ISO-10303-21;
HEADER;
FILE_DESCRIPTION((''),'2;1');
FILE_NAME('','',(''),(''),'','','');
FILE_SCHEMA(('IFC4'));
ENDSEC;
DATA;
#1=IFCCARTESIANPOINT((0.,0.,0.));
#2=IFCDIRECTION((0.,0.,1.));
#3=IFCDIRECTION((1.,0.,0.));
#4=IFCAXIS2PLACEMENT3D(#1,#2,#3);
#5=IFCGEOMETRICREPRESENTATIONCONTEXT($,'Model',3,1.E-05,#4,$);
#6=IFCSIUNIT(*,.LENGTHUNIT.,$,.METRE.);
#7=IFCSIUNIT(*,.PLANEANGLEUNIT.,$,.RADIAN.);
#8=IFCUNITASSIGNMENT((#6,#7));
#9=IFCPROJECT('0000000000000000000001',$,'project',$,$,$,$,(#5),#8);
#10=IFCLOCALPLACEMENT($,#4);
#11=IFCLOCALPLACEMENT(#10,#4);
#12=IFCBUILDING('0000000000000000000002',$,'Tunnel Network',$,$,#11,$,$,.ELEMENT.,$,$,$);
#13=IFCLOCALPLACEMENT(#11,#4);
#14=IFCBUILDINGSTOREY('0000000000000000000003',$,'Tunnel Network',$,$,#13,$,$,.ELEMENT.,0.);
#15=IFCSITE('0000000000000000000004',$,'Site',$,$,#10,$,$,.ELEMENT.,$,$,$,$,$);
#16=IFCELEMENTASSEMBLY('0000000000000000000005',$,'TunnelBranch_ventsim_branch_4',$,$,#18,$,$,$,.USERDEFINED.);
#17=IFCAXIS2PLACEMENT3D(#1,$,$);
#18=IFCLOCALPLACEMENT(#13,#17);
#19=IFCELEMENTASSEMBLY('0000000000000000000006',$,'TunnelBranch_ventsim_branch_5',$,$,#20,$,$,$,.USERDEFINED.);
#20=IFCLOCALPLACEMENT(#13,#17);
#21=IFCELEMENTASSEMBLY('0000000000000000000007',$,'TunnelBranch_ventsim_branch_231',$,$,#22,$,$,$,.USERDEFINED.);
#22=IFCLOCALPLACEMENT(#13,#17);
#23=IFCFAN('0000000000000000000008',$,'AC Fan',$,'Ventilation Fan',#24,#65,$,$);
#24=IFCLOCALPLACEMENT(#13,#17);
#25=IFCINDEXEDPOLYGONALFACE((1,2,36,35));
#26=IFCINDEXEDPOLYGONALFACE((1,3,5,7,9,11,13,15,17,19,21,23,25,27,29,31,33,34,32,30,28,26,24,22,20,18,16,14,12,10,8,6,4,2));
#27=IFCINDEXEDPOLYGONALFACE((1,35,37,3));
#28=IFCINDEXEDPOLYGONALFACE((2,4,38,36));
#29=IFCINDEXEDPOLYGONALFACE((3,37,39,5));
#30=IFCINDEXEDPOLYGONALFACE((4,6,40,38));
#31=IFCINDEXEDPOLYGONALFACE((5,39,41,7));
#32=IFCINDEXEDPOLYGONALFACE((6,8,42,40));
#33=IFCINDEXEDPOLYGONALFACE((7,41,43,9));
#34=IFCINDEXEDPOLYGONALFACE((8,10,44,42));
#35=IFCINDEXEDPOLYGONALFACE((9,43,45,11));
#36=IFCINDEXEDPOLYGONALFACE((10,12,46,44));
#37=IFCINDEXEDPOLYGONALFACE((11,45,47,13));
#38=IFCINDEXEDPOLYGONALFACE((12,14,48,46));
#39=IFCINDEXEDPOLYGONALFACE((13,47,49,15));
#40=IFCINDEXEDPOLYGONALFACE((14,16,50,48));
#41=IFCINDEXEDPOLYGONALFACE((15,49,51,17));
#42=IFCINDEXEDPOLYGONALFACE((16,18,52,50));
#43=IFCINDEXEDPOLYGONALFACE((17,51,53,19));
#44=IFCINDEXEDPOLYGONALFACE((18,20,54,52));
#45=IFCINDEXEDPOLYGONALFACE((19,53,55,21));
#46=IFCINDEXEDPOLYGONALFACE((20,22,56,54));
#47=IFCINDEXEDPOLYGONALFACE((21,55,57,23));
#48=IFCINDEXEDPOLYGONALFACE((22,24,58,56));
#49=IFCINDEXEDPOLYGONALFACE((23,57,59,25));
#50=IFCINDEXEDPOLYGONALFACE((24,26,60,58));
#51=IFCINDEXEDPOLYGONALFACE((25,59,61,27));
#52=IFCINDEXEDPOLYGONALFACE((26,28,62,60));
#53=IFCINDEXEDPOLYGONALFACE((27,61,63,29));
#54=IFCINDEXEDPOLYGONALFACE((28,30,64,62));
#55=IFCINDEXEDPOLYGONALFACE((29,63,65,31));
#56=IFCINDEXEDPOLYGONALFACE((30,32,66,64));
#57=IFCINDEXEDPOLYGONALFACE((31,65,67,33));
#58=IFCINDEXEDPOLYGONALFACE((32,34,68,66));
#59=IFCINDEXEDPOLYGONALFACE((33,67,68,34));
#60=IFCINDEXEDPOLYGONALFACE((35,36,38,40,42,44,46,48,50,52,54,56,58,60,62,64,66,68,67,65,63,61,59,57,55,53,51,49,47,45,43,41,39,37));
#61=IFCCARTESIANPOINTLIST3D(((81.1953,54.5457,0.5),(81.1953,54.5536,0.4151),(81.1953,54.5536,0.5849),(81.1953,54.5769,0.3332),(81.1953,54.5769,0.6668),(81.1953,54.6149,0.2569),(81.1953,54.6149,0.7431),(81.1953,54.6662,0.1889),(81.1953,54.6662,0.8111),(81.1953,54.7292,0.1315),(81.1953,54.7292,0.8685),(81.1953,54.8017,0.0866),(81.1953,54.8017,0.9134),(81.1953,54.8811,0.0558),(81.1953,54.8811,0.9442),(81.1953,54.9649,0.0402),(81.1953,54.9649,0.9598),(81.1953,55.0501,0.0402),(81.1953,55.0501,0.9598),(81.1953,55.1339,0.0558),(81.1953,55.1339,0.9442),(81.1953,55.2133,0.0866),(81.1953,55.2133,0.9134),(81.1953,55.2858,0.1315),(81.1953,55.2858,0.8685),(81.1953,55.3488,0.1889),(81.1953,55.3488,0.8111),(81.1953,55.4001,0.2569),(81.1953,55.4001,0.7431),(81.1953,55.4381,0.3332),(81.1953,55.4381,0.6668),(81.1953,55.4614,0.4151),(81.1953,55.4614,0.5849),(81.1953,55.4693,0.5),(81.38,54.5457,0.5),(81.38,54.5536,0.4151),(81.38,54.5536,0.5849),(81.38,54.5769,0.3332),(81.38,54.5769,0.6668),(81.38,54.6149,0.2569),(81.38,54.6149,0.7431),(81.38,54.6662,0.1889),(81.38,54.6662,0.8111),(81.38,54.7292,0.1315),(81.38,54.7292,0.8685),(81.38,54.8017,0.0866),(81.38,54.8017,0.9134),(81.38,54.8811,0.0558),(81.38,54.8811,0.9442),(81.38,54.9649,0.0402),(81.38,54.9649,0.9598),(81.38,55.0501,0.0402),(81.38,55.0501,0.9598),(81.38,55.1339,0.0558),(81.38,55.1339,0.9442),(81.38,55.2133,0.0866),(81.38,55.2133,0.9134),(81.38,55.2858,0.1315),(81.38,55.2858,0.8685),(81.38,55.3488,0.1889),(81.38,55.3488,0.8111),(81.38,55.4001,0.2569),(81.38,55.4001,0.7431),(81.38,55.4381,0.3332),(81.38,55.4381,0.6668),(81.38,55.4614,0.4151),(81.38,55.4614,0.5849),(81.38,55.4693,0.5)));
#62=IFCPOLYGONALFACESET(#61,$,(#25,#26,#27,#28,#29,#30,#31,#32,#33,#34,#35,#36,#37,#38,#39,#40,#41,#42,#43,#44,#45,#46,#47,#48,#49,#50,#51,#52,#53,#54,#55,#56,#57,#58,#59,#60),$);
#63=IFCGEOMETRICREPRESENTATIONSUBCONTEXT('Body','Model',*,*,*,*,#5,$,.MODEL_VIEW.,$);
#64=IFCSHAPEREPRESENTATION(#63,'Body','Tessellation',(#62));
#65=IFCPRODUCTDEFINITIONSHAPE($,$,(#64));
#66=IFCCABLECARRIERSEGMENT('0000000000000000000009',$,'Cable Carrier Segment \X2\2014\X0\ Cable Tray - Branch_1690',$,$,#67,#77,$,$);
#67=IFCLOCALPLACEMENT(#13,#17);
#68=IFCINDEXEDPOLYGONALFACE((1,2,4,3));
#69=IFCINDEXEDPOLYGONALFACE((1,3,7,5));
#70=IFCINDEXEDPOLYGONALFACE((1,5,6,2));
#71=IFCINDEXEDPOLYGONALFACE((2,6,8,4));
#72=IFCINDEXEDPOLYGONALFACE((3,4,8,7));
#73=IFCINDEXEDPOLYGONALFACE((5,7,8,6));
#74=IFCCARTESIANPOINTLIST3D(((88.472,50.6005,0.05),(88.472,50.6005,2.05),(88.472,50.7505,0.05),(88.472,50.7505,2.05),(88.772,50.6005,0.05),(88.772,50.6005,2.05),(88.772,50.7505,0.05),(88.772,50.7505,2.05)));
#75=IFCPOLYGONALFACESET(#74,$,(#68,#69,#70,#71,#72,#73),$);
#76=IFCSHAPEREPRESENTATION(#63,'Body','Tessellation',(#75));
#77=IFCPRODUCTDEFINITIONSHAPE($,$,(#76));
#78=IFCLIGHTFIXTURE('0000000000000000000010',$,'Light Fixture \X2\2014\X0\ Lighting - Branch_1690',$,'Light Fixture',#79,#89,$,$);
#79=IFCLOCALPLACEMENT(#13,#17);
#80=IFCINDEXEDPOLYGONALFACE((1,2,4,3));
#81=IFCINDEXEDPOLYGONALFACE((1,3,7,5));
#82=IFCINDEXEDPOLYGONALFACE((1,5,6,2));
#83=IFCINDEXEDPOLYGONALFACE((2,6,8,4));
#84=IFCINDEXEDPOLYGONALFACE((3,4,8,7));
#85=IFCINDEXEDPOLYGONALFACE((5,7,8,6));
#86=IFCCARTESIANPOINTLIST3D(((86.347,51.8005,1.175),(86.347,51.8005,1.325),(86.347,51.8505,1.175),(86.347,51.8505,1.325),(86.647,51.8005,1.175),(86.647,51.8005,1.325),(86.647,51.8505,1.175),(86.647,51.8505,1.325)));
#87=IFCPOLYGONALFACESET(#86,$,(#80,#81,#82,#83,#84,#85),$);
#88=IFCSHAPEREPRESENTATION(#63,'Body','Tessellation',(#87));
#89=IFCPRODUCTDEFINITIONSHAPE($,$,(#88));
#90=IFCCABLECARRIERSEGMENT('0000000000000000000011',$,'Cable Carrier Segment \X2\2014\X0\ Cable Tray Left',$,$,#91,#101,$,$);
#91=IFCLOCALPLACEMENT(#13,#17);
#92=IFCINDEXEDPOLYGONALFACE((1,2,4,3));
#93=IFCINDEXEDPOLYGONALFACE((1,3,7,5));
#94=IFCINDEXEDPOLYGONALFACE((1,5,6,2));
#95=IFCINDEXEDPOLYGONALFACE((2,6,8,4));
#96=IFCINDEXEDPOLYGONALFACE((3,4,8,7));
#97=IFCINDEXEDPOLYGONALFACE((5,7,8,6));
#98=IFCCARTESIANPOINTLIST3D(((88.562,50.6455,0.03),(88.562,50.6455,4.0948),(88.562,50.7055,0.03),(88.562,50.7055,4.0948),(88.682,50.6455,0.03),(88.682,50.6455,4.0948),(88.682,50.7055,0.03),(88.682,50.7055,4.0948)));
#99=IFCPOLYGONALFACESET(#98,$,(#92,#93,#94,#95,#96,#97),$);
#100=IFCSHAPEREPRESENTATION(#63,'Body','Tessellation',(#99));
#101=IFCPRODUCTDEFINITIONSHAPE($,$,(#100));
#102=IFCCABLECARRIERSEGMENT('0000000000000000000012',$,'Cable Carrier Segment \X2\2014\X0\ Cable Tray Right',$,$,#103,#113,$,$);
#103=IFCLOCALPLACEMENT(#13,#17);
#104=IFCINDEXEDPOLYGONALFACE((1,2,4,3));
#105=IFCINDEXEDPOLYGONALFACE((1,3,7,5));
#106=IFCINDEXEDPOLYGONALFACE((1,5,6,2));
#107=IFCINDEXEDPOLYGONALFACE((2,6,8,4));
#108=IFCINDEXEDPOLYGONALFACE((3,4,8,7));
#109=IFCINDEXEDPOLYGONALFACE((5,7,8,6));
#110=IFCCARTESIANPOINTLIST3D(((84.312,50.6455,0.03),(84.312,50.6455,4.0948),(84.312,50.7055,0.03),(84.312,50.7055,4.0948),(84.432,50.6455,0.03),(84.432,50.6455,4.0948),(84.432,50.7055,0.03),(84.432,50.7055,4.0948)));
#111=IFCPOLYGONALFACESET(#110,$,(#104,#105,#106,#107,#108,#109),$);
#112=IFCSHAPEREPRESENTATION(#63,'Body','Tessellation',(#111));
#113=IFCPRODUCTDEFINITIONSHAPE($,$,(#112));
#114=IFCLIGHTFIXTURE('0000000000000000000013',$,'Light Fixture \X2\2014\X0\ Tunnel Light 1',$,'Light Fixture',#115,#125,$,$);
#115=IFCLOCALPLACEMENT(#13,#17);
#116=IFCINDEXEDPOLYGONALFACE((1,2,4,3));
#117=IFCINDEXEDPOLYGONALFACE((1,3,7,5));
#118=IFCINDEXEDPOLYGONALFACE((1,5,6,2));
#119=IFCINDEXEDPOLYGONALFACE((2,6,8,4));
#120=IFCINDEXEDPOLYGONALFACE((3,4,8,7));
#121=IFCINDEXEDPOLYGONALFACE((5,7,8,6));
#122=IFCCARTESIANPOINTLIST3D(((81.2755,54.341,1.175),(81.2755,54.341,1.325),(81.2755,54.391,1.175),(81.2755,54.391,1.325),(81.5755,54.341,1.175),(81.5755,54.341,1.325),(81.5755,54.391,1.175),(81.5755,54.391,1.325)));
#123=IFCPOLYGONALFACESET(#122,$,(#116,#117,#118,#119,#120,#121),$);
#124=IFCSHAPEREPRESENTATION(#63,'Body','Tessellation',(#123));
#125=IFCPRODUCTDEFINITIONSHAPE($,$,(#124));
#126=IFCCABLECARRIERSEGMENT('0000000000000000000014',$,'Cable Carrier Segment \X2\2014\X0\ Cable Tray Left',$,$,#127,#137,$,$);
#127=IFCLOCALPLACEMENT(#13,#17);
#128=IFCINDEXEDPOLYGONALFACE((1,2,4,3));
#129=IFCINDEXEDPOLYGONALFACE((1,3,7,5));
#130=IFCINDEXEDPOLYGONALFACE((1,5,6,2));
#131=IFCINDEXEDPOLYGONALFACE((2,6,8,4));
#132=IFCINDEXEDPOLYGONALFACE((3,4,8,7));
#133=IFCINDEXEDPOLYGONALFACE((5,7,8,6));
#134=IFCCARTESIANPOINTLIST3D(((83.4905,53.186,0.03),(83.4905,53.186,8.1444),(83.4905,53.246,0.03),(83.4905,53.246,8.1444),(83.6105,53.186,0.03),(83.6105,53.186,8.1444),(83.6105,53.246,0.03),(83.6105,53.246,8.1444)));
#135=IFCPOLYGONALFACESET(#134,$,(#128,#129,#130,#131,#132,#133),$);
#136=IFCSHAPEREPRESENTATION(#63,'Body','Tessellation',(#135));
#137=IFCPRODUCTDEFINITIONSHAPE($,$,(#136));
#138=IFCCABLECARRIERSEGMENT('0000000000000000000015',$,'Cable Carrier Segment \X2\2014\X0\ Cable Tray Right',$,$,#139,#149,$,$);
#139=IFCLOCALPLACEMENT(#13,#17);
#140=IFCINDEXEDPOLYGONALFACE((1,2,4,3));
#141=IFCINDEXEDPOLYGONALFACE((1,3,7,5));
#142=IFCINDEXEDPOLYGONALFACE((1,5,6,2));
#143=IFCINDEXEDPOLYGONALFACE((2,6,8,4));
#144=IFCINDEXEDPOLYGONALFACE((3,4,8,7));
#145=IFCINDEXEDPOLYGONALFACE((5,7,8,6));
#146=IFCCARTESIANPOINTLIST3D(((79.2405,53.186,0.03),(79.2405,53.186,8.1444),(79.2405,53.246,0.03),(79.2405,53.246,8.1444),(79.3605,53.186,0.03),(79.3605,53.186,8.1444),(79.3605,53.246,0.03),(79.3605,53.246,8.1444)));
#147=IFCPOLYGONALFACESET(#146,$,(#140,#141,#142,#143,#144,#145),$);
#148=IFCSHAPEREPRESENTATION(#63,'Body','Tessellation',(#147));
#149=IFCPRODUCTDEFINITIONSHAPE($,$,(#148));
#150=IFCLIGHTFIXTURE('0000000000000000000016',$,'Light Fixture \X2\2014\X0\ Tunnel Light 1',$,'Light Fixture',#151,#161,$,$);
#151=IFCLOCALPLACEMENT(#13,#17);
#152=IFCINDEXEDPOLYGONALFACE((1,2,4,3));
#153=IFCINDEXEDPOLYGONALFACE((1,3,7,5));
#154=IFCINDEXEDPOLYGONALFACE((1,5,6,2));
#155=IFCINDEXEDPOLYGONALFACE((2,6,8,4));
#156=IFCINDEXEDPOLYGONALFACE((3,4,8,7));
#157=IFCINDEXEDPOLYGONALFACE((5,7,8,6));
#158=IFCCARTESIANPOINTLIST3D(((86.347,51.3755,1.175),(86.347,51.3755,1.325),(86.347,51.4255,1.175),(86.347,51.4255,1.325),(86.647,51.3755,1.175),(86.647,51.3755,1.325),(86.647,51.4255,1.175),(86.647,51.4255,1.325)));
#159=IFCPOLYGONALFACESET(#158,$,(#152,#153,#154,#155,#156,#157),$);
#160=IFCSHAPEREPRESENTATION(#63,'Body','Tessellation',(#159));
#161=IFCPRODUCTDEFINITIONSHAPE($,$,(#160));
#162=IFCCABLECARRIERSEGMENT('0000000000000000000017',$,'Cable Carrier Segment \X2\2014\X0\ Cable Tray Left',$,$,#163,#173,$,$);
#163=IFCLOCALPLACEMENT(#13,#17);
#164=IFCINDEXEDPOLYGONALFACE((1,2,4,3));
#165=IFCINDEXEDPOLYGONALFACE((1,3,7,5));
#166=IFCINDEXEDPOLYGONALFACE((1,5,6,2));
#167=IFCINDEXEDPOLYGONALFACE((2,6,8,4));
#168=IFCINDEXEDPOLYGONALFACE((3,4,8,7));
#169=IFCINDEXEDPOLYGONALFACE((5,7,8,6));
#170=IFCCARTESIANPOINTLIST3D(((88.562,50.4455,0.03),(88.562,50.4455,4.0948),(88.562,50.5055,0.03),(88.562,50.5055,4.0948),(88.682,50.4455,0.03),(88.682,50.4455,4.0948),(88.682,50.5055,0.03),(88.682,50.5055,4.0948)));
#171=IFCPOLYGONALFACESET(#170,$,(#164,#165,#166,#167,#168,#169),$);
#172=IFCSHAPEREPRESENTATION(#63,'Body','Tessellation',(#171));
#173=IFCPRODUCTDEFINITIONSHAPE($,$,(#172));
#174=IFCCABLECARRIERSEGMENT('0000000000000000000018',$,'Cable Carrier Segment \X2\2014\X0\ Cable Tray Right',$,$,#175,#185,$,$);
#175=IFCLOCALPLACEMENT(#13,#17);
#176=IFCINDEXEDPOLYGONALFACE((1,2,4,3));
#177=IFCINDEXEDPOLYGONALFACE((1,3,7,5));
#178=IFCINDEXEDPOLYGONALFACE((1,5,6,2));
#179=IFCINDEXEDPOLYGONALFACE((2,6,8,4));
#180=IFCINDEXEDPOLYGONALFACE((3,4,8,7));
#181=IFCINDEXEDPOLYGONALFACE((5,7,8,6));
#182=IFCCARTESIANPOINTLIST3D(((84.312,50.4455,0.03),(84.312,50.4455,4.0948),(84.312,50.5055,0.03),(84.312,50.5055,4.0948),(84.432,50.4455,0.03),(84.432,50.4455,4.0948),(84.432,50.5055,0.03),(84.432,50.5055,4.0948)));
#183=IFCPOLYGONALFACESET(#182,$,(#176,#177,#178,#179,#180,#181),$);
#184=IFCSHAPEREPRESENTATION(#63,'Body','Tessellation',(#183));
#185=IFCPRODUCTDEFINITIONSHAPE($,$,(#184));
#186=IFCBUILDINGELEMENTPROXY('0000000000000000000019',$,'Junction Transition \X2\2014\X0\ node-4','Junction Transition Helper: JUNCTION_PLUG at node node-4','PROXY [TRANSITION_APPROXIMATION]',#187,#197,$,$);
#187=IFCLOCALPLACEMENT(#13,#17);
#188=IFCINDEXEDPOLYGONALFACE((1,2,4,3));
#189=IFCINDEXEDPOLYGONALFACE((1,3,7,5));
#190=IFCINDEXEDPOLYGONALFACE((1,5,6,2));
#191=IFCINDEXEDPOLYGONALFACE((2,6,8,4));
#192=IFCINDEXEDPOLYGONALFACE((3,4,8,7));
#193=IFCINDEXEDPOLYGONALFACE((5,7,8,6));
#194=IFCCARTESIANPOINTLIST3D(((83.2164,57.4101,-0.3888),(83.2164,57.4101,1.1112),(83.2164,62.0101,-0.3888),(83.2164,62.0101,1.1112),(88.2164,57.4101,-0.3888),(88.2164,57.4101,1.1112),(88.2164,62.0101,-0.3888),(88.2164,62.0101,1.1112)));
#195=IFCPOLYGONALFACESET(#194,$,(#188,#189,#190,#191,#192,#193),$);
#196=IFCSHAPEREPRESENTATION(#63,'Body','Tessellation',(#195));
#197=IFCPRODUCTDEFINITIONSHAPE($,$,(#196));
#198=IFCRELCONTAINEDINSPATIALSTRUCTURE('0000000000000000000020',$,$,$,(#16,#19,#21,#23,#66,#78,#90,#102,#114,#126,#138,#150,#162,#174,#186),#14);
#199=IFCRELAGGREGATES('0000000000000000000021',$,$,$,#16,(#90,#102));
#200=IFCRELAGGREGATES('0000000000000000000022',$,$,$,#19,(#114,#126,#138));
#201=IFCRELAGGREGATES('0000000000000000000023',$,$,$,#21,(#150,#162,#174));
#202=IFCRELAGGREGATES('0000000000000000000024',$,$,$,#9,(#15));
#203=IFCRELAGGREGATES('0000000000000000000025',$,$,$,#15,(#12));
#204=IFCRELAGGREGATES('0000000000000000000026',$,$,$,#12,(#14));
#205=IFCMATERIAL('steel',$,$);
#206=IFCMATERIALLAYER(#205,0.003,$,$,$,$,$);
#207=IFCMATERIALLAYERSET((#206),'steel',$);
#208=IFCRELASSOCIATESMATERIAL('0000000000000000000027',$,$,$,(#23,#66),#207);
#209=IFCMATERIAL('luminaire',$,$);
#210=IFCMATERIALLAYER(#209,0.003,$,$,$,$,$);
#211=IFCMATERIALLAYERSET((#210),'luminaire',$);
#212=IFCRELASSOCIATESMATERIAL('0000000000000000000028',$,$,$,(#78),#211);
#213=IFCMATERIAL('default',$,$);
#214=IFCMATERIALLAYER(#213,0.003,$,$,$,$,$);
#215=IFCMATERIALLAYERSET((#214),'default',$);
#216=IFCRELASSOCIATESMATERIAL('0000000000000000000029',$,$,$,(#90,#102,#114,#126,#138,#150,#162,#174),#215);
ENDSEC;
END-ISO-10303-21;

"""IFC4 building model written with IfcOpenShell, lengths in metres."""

from ifc_helpers import new_model, si_unit, frame, origin_with_axes, origin_2d_with_axis, place, context, subcontext, project, spatial, rectangle, circle, extrude, material, layer, layer_set, layer_usage, element, aggregate, save


model = new_model("IFC4")

# Units and contexts
model_context = context("Model", 3, precision=1e-05, world=origin_with_axes())
body_context = subcontext(model_context, "Body", "Model", "MODEL_VIEW")
ifc_project = project(units=[si_unit("LENGTHUNIT", "METRE"), si_unit("PLANEANGLEUNIT", "RADIAN")], contexts=[model_context])

# Site, building, storey
site_placement = place(None, origin_with_axes())
site = spatial("IfcSite", under=ifc_project, at=site_placement, Name="Site", CompositionType="ELEMENT")
building_placement = place(site_placement, origin_with_axes())
building = spatial("IfcBuilding", under=site, at=building_placement, Name="Tunnel Network", CompositionType="ELEMENT")
storey_placement = place(building_placement, origin_with_axes())
storey = spatial("IfcBuildingStorey", under=building, at=storey_placement, Name="Tunnel Network", CompositionType="ELEMENT", Elevation=0.0)

# Element assemblies
assembly_1_placement = place(storey_placement, frame((86.497, 51.8005, 0.5081), z_axis=(0.0, 0.0, 1.0), x_axis=(-1.0, 0.0, 0.0)))
assembly_1 = element("IfcElementAssembly", 1, at=assembly_1_placement, inside=storey, Name="TunnelBranch_ventsim_branch_4", PredefinedType="USERDEFINED")
ifc_material_1 = material(Name="default")
ifc_layer_1 = layer(ifc_material_1, 0.003)
ifc_layer_set_1 = layer_set([ifc_layer_1], Name="default")
assembly_2_placement = place(storey_placement, frame((78.9255, 52.216, 4.0), z_axis=(0.0, 1.0, 0.0), x_axis=(-1.0, 0.0, 0.0)))
assembly_2 = element("IfcElementAssembly", 2, at=assembly_2_placement, inside=storey, Name="TunnelBranch_ventsim_branch_5", PredefinedType="USERDEFINED")
assembly_3_placement = place(storey_placement, frame((86.497, 51.3755, 1.25), z_axis=(0.0, 1.0, 0.0), x_axis=(-1.0, 0.0, 0.0)))
assembly_3 = element("IfcElementAssembly", 3, at=assembly_3_placement, inside=storey, Name="TunnelBranch_ventsim_branch_231", PredefinedType="USERDEFINED")

# Fan
ifc_material_2 = material(Name="steel")
ifc_layer_2 = layer(ifc_material_2, 0.003)
ifc_layer_set_2 = layer_set([ifc_layer_2], Name="steel")
ifc_layer_usage_1 = layer_usage(ifc_layer_set_2, "AXIS2", "POSITIVE", 0.0)
fan_placement = place(storey_placement, frame((81.38, 55.0075, 0.5), z_axis=(-1.0, 0.0, 0.0), x_axis=(0.0, 1.0, 0.0)))
element("IfcFan", 4, at=fan_placement, inside=storey, material=ifc_layer_usage_1, Name="AC Fan", ObjectType="Ventilation Fan", context=body_context, shape_type="SweptSolid", body=[
    extrude(circle(Radius=0.4618, at=origin_2d_with_axis()), origin_with_axes(), (0.0, 0.0, 1.0), 0.1847),
])

# Cable carrier segment
ifc_layer_usage_2 = layer_usage(ifc_layer_set_2, "AXIS2", "POSITIVE", 0.0)
cable_carrier_segment_1_placement = place(storey_placement, frame((88.622, 50.6755, 0.05), z_axis=(0.0, 0.0, 1.0), x_axis=(-1.0, 0.0, 0.0)))
element("IfcCableCarrierSegment", 5, at=cable_carrier_segment_1_placement, inside=storey, material=ifc_layer_usage_2, Name="Cable Carrier Segment — Cable Tray - Branch_1690", context=body_context, shape_type="SweptSolid", body=[
    extrude(rectangle(XDim=0.3, YDim=0.15, at=origin_2d_with_axis()), origin_with_axes(), (0.0, 0.0, 1.0), 2.0),
])

# Light fixture
ifc_material_3 = material(Name="luminaire")
ifc_layer_3 = layer(ifc_material_3, 0.003)
ifc_layer_set_3 = layer_set([ifc_layer_3], Name="luminaire")
ifc_layer_usage_3 = layer_usage(ifc_layer_set_3, "AXIS2", "POSITIVE", 0.0)
light_fixture_1_placement = place(storey_placement, frame((86.497, 51.8005, 1.25), z_axis=(0.0, 1.0, 0.0), x_axis=(-1.0, 0.0, 0.0)))
element("IfcLightFixture", 6, at=light_fixture_1_placement, inside=storey, material=ifc_layer_usage_3, Name="Light Fixture — Lighting - Branch_1690", ObjectType="Light Fixture", context=body_context, shape_type="SweptSolid", body=[
    extrude(rectangle(XDim=0.3, YDim=0.15, at=origin_2d_with_axis()), origin_with_axes(), (0.0, 0.0, 1.0), 0.05),
])

# Cable carrier segments
ifc_layer_usage_4 = layer_usage(ifc_layer_set_1, "AXIS2", "POSITIVE", 0.0)
cable_carrier_segment_2_placement = place(storey_placement, frame((88.622, 50.6755, 0.03), z_axis=(0.0, 0.0, 1.0), x_axis=(-1.0, 0.0, 0.0)))
cable_carrier_segment_2 = element("IfcCableCarrierSegment", 7, at=cable_carrier_segment_2_placement, inside=storey, material=ifc_layer_usage_4, Name="Cable Carrier Segment — Cable Tray Left", context=body_context, shape_type="SweptSolid", body=[
    extrude(rectangle(XDim=0.12, YDim=0.06, at=origin_2d_with_axis()), origin_with_axes(), (0.0, 0.0, 1.0), 4.0648),
])
ifc_layer_usage_5 = layer_usage(ifc_layer_set_1, "AXIS2", "POSITIVE", 0.0)
cable_carrier_segment_3_placement = place(storey_placement, frame((84.372, 50.6755, 0.03), z_axis=(0.0, 0.0, 1.0), x_axis=(-1.0, 0.0, 0.0)))
cable_carrier_segment_3 = element("IfcCableCarrierSegment", 8, at=cable_carrier_segment_3_placement, inside=storey, material=ifc_layer_usage_5, Name="Cable Carrier Segment — Cable Tray Right", context=body_context, shape_type="SweptSolid", body=[
    extrude(rectangle(XDim=0.12, YDim=0.06, at=origin_2d_with_axis()), origin_with_axes(), (0.0, 0.0, 1.0), 4.0648),
])
aggregate(assembly_1, [cable_carrier_segment_2, cable_carrier_segment_3])

# Light fixture
ifc_layer_usage_6 = layer_usage(ifc_layer_set_1, "AXIS2", "POSITIVE", 0.0)
light_fixture_2_placement = place(storey_placement, frame((81.4255, 54.341, 1.25), z_axis=(0.0, 1.0, 0.0), x_axis=(-1.0, 0.0, 0.0)))
light_fixture_2 = element("IfcLightFixture", 9, at=light_fixture_2_placement, inside=storey, material=ifc_layer_usage_6, Name="Light Fixture — Tunnel Light 1", ObjectType="Light Fixture", context=body_context, shape_type="SweptSolid", body=[
    extrude(rectangle(XDim=0.3, YDim=0.15, at=origin_2d_with_axis()), origin_with_axes(), (0.0, 0.0, 1.0), 0.05),
])

# Cable carrier segments
ifc_layer_usage_7 = layer_usage(ifc_layer_set_1, "AXIS2", "POSITIVE", 0.0)
cable_carrier_segment_4_placement = place(storey_placement, frame((83.5505, 53.216, 0.03), z_axis=(0.0, 0.0, 1.0), x_axis=(-1.0, 0.0, 0.0)))
cable_carrier_segment_4 = element("IfcCableCarrierSegment", 10, at=cable_carrier_segment_4_placement, inside=storey, material=ifc_layer_usage_7, Name="Cable Carrier Segment — Cable Tray Left", context=body_context, shape_type="SweptSolid", body=[
    extrude(rectangle(XDim=0.12, YDim=0.06, at=origin_2d_with_axis()), origin_with_axes(), (0.0, 0.0, 1.0), 8.1144),
])
ifc_layer_usage_8 = layer_usage(ifc_layer_set_1, "AXIS2", "POSITIVE", 0.0)
cable_carrier_segment_5_placement = place(storey_placement, frame((79.3005, 53.216, 0.03), z_axis=(0.0, 0.0, 1.0), x_axis=(-1.0, 0.0, 0.0)))
cable_carrier_segment_5 = element("IfcCableCarrierSegment", 11, at=cable_carrier_segment_5_placement, inside=storey, material=ifc_layer_usage_8, Name="Cable Carrier Segment — Cable Tray Right", context=body_context, shape_type="SweptSolid", body=[
    extrude(rectangle(XDim=0.12, YDim=0.06, at=origin_2d_with_axis()), origin_with_axes(), (0.0, 0.0, 1.0), 8.1144),
])
aggregate(assembly_2, [light_fixture_2, cable_carrier_segment_4, cable_carrier_segment_5])

# Light fixture
ifc_layer_usage_9 = layer_usage(ifc_layer_set_1, "AXIS2", "POSITIVE", 0.0)
light_fixture_3_placement = place(storey_placement, frame((86.497, 51.3755, 1.25), z_axis=(0.0, 1.0, 0.0), x_axis=(-1.0, 0.0, 0.0)))
light_fixture_3 = element("IfcLightFixture", 12, at=light_fixture_3_placement, inside=storey, material=ifc_layer_usage_9, Name="Light Fixture — Tunnel Light 1", ObjectType="Light Fixture", context=body_context, shape_type="SweptSolid", body=[
    extrude(rectangle(XDim=0.3, YDim=0.15, at=origin_2d_with_axis()), origin_with_axes(), (0.0, 0.0, 1.0), 0.05),
])

# Cable carrier segments
ifc_layer_usage_10 = layer_usage(ifc_layer_set_1, "AXIS2", "POSITIVE", 0.0)
cable_carrier_segment_6_placement = place(storey_placement, frame((88.622, 50.4755, 0.03), z_axis=(0.0, 0.0, 1.0), x_axis=(-1.0, 0.0, 0.0)))
cable_carrier_segment_6 = element("IfcCableCarrierSegment", 13, at=cable_carrier_segment_6_placement, inside=storey, material=ifc_layer_usage_10, Name="Cable Carrier Segment — Cable Tray Left", context=body_context, shape_type="SweptSolid", body=[
    extrude(rectangle(XDim=0.12, YDim=0.06, at=origin_2d_with_axis()), origin_with_axes(), (0.0, 0.0, 1.0), 4.0648),
])
ifc_layer_usage_11 = layer_usage(ifc_layer_set_1, "AXIS2", "POSITIVE", 0.0)
cable_carrier_segment_7_placement = place(storey_placement, frame((84.372, 50.4755, 0.03), z_axis=(0.0, 0.0, 1.0), x_axis=(-1.0, 0.0, 0.0)))
cable_carrier_segment_7 = element("IfcCableCarrierSegment", 14, at=cable_carrier_segment_7_placement, inside=storey, material=ifc_layer_usage_11, Name="Cable Carrier Segment — Cable Tray Right", context=body_context, shape_type="SweptSolid", body=[
    extrude(rectangle(XDim=0.12, YDim=0.06, at=origin_2d_with_axis()), origin_with_axes(), (0.0, 0.0, 1.0), 4.0648),
])
aggregate(assembly_3, [light_fixture_3, cable_carrier_segment_6, cable_carrier_segment_7])

# Building element proxy
proxy_1_placement = place(storey_placement, frame((85.7164, 59.7101, -0.3888), z_axis=(0.0, 0.0, 1.0), x_axis=(1.0, 0.0, 0.0)))
element("IfcBuildingElementProxy", 15, at=proxy_1_placement, inside=storey, Name="Junction Transition — node-4", Description="Junction Transition Helper: JUNCTION_PLUG at node node-4", ObjectType="PROXY [TRANSITION_APPROXIMATION]", context=body_context, shape_type="SweptSolid", body=[
    extrude(rectangle(XDim=5.0, YDim=4.6, at=origin_2d_with_axis()), origin_with_axes(), (0.0, 0.0, 1.0), 1.5),
])

save(model, "model.ifc")
